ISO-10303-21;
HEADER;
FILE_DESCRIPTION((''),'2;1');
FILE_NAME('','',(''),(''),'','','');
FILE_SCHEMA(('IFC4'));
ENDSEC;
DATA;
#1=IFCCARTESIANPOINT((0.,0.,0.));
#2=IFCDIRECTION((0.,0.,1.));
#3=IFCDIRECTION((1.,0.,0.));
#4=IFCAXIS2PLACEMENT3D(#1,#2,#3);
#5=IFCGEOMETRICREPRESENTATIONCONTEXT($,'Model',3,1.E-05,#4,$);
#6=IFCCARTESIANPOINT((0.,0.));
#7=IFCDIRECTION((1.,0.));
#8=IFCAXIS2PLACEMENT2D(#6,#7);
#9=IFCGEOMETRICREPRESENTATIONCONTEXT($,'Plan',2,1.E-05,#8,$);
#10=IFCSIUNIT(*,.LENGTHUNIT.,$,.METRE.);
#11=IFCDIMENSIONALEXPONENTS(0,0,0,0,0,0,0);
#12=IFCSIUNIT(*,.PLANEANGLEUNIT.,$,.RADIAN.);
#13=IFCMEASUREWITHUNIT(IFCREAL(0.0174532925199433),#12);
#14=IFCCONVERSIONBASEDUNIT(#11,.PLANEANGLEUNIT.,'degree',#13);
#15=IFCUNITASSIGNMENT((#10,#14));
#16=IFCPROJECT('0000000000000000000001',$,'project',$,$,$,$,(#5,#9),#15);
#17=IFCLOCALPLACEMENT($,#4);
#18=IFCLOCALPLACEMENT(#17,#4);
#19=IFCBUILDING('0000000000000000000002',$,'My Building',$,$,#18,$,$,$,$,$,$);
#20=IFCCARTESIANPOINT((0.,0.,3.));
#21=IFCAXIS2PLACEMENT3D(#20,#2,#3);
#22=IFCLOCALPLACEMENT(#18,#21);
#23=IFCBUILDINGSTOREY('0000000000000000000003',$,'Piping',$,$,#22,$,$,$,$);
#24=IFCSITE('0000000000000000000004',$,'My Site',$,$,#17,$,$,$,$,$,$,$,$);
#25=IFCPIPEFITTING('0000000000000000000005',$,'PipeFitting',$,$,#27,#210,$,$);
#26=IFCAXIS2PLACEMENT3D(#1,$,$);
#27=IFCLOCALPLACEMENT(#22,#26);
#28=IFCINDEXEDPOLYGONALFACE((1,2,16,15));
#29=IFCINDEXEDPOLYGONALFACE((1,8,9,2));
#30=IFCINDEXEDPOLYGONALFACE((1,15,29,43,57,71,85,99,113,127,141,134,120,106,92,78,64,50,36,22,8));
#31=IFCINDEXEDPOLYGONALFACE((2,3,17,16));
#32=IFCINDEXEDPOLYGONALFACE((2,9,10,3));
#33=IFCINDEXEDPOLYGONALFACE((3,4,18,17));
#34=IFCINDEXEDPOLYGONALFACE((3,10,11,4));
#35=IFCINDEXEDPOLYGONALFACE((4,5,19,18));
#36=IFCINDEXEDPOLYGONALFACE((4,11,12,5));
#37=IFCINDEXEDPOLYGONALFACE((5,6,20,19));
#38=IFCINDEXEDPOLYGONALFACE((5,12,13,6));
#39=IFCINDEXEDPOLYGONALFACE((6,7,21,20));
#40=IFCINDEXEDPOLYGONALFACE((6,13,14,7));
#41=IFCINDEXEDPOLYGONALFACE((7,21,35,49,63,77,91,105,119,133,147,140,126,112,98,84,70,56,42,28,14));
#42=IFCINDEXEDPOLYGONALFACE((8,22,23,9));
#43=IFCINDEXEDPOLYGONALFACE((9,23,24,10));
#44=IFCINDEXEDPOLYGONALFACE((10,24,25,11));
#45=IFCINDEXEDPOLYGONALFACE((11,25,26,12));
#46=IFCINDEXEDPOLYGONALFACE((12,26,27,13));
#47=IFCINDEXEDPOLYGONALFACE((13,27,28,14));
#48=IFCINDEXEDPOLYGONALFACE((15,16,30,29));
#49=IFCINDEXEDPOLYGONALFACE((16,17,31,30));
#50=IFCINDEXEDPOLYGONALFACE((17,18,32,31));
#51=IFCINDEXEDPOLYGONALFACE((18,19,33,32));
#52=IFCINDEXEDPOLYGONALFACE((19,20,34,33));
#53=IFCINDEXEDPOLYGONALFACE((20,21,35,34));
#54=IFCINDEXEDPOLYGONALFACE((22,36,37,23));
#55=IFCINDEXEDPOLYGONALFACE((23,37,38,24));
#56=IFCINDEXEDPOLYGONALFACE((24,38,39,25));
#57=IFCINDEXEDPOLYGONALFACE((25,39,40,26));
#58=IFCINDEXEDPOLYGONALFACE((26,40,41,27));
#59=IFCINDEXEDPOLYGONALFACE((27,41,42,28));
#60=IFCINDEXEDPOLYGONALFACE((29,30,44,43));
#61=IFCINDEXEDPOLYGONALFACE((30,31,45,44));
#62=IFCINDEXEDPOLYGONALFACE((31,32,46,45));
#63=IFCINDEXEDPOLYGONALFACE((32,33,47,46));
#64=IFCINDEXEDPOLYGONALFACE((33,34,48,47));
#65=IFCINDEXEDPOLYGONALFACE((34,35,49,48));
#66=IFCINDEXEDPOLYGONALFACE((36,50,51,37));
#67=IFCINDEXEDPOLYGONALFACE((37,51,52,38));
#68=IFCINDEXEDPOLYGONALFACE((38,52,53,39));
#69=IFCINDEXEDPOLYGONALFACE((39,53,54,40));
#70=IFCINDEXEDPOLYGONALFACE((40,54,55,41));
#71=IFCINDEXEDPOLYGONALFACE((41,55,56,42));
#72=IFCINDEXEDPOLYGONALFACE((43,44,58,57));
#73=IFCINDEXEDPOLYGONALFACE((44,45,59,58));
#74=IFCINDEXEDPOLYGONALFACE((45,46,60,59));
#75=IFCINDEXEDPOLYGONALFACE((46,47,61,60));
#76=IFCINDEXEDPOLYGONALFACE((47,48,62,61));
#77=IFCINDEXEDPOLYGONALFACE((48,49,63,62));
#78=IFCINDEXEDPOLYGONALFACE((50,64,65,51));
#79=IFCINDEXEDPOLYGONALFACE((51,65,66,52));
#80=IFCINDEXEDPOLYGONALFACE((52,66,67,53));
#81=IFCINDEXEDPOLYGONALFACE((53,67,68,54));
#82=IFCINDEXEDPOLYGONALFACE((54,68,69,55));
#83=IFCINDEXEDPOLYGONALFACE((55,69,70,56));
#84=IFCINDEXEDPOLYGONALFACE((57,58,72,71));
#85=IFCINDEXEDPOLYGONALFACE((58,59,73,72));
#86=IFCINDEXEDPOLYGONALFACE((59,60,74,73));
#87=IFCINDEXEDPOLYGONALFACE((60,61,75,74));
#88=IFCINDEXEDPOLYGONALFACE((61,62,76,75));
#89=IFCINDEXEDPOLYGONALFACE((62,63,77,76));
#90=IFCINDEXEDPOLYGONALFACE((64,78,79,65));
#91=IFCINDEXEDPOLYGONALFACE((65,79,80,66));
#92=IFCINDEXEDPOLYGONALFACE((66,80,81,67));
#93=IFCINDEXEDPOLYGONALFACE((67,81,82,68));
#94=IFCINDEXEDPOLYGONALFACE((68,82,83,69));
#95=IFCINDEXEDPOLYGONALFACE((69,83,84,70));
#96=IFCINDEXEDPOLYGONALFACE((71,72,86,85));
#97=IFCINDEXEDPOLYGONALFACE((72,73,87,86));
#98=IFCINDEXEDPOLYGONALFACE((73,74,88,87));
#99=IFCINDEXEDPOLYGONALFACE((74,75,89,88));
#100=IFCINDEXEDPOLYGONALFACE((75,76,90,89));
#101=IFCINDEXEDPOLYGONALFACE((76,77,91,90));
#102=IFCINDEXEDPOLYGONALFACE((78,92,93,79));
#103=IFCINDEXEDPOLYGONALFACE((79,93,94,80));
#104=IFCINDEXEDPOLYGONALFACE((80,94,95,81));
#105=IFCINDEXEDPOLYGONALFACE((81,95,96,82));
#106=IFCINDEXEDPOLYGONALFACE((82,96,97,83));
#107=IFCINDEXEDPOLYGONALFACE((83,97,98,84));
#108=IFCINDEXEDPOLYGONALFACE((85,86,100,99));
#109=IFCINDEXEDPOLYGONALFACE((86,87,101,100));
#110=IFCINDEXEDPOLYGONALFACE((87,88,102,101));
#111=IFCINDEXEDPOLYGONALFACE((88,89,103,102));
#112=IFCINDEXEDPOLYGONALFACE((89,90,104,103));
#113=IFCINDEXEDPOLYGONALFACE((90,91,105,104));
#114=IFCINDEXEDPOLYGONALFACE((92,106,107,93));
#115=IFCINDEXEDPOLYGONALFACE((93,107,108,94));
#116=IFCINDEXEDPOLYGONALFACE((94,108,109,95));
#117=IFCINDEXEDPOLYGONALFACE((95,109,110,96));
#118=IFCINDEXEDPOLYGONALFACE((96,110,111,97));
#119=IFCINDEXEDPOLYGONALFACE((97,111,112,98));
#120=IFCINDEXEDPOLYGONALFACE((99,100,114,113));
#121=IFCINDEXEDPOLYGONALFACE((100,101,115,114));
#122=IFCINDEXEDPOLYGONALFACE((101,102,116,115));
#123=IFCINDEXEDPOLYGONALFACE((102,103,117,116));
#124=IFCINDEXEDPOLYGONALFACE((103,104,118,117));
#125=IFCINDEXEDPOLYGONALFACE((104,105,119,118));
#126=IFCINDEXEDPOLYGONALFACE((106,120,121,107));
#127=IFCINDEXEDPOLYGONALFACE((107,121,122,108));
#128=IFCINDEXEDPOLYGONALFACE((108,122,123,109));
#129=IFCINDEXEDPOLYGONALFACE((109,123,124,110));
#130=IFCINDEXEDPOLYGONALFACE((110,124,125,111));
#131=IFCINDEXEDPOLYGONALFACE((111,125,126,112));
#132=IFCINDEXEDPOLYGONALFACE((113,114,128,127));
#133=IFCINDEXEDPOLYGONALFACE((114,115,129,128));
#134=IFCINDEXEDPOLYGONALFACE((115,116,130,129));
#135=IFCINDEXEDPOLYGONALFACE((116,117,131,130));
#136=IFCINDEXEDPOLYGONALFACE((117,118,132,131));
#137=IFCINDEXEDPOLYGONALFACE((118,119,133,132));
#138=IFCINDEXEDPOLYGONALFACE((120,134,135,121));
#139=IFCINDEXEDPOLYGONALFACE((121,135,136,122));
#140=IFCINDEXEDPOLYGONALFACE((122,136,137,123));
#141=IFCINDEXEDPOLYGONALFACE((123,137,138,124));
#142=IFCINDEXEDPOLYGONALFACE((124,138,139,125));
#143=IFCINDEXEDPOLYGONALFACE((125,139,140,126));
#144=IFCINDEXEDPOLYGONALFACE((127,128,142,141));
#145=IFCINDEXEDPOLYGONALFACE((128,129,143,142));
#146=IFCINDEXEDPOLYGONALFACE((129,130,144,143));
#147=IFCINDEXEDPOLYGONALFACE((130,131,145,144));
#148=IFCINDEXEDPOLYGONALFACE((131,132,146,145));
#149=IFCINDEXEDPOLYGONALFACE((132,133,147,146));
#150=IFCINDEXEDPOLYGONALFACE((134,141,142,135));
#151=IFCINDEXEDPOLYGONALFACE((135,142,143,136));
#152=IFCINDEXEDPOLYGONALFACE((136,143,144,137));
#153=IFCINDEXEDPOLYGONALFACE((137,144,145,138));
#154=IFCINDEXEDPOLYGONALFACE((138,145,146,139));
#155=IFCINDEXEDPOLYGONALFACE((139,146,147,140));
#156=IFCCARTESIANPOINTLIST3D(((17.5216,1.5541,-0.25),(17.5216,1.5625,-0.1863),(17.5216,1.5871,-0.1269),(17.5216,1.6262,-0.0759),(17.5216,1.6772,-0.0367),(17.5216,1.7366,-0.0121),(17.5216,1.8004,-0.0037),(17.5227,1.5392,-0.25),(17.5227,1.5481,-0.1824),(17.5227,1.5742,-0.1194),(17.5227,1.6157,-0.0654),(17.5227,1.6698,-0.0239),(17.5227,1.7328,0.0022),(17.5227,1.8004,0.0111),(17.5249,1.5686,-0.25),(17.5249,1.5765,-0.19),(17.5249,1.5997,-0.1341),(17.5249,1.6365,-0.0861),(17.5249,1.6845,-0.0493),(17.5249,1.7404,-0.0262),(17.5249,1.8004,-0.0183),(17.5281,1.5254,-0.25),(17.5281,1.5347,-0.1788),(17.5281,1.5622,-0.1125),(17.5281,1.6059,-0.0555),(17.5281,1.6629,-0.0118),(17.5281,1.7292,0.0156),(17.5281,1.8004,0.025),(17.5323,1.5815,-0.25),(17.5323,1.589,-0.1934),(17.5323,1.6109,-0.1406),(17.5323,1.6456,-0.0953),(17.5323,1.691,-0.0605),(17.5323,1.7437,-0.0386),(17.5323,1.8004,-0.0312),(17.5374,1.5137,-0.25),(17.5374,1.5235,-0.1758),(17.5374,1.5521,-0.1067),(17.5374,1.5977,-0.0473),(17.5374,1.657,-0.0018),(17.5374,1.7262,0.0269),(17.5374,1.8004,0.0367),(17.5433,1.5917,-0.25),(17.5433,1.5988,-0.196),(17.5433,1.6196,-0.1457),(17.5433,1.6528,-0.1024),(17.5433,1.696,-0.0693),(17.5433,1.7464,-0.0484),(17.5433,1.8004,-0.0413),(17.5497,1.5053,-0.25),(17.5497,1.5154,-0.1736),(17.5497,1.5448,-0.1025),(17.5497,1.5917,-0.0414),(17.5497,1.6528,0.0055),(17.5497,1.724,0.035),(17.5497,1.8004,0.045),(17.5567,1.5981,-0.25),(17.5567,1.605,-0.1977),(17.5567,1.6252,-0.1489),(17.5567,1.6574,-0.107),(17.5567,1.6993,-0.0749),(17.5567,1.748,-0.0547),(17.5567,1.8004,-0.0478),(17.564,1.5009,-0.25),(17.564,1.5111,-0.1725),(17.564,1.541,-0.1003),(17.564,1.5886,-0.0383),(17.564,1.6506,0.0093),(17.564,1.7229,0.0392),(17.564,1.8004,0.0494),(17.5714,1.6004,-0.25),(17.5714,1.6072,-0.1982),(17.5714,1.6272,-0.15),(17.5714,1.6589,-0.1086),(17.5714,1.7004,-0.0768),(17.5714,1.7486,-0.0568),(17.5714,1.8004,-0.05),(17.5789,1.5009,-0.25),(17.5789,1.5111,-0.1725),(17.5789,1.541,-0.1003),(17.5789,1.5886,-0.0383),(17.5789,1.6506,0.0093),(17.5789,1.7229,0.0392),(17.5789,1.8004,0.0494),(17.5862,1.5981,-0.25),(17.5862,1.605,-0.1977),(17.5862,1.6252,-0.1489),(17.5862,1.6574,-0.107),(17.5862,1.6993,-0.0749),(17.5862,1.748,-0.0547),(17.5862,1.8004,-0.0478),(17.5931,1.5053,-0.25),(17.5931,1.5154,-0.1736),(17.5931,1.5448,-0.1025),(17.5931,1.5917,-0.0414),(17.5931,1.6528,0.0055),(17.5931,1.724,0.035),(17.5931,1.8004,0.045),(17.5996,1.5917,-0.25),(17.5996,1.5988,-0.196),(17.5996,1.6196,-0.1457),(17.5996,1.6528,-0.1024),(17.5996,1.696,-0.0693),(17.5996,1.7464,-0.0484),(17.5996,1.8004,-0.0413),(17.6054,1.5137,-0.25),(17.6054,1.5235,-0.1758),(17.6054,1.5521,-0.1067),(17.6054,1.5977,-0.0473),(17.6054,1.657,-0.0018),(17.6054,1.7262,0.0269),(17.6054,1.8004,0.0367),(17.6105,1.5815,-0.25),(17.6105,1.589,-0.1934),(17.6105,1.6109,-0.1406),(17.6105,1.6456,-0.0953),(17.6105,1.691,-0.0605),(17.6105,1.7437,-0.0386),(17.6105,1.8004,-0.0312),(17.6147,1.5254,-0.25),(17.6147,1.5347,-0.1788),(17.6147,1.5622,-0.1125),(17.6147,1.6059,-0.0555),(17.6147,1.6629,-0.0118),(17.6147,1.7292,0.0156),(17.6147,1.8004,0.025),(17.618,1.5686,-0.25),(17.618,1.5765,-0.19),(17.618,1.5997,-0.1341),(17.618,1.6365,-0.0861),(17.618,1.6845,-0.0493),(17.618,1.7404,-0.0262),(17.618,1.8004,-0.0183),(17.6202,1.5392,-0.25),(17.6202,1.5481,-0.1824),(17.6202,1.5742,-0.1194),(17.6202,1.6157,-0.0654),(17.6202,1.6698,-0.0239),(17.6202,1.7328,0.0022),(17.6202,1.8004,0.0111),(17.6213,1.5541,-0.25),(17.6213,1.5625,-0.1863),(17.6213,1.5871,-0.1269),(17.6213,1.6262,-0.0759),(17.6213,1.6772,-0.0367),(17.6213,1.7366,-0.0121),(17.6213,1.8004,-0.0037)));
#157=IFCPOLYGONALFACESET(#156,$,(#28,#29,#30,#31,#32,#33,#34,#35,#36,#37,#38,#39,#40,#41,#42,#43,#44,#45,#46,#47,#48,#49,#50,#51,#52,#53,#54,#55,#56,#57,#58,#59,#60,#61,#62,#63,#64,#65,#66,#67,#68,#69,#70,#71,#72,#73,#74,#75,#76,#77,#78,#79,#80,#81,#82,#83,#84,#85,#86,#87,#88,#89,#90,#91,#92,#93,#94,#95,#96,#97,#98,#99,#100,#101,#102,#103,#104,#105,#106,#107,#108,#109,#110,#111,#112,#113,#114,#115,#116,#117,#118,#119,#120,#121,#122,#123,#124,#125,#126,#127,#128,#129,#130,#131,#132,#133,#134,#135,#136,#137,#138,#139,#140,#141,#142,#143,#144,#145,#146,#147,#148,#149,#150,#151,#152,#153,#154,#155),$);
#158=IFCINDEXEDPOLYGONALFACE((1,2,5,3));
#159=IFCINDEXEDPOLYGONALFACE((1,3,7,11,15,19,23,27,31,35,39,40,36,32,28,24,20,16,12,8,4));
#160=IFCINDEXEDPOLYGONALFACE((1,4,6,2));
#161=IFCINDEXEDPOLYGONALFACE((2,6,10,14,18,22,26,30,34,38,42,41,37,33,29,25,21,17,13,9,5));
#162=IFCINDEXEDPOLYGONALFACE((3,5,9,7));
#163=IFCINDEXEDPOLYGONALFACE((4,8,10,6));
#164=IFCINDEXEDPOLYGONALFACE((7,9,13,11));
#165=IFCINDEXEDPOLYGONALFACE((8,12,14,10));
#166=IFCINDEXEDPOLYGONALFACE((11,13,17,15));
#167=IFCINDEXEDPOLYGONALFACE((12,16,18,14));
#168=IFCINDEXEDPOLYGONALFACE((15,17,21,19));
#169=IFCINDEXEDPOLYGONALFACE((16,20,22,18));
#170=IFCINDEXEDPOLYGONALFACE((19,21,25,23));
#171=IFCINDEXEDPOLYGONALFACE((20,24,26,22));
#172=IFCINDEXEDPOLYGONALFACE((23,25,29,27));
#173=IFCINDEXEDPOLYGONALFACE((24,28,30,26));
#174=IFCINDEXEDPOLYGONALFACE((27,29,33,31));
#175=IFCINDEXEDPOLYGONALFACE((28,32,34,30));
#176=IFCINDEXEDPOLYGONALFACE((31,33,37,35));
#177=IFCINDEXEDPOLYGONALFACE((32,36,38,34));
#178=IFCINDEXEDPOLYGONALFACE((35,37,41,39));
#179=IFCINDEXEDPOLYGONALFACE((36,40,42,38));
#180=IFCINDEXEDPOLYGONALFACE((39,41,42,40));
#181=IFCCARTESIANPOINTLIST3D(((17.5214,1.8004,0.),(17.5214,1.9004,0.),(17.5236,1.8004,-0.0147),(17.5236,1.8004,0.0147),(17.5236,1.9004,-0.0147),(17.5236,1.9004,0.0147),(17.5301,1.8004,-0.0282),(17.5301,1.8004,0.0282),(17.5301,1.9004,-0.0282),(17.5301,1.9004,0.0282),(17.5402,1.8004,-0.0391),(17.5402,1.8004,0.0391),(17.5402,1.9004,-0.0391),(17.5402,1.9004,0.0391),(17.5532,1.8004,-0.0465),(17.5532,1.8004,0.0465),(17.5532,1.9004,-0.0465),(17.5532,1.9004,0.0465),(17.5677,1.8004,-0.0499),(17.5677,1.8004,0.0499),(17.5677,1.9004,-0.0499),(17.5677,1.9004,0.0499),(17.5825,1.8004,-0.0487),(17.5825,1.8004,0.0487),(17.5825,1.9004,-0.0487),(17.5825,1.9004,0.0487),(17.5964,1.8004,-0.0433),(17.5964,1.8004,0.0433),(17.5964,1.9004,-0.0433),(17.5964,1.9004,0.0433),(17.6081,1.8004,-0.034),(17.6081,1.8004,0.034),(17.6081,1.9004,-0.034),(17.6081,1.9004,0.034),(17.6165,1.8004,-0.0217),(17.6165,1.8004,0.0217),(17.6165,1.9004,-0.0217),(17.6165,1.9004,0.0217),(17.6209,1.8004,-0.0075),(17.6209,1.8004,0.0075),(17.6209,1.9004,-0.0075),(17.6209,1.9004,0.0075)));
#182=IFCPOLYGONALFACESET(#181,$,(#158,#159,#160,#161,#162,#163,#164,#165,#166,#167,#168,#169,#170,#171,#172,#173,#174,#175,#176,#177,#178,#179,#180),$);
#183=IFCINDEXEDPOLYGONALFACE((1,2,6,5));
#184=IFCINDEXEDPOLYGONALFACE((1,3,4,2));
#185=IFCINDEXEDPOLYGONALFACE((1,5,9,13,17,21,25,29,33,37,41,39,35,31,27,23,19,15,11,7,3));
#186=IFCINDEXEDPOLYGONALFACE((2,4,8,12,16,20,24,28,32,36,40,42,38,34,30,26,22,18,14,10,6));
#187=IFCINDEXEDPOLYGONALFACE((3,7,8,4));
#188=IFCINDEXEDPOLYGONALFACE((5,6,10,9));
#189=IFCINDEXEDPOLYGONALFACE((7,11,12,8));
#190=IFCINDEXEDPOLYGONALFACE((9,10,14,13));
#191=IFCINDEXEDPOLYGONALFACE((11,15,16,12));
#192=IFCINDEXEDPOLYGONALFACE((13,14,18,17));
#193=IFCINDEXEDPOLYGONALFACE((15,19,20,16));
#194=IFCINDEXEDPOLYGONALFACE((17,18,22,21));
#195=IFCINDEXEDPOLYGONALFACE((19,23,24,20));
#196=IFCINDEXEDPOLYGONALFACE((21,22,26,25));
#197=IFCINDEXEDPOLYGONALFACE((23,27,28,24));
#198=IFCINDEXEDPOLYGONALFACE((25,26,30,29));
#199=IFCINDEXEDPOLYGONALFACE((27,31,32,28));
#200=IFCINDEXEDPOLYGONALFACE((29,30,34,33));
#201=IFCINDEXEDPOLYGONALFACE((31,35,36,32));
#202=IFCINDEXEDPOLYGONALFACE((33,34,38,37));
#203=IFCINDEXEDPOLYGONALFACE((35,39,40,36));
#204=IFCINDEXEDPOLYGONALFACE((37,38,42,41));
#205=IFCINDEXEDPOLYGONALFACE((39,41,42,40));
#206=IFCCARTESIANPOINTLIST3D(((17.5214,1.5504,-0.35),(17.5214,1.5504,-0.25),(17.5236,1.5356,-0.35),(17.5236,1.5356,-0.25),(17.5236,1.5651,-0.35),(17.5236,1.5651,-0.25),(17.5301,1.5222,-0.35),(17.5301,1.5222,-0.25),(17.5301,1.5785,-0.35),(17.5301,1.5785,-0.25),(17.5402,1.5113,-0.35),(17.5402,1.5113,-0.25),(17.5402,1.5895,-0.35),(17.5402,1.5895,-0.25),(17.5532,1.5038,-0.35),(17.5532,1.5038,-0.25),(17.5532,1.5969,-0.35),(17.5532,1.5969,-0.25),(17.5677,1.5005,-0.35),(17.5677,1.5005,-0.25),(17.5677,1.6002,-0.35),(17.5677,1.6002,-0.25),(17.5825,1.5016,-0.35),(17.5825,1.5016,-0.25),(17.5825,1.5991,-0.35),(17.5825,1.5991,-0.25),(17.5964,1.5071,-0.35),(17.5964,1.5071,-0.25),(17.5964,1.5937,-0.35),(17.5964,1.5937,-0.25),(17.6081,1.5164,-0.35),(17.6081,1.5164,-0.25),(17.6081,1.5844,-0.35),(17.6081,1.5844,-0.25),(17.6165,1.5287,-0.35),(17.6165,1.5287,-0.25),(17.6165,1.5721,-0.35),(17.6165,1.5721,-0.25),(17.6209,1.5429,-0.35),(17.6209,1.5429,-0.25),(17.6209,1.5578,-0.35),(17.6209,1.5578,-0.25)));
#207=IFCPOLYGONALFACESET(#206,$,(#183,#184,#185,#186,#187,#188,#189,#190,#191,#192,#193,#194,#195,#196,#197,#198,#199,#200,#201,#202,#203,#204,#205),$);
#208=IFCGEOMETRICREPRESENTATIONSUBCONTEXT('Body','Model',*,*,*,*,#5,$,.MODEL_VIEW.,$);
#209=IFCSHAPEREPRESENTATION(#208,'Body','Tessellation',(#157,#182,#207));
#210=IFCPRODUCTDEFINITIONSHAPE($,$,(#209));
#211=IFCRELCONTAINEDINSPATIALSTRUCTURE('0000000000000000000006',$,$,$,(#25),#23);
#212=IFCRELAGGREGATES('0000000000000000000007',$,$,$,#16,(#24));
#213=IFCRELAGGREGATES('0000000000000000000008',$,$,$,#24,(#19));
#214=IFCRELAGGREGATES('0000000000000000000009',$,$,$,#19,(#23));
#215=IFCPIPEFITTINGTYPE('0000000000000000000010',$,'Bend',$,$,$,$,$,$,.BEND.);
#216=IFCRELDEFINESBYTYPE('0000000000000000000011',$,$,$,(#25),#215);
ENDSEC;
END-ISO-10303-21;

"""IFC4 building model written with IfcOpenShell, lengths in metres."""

from ifc_helpers import new_model, entity, si_unit, converted_unit, frame, origin_with_axes, origin_2d_with_axis, place, context, subcontext, project, spatial, circle, extrude, source, transform, mapped, type_object, type_shapes, element, save


model = new_model("IFC4")

# Units and contexts
model_context = context("Model", 3, precision=1e-05, world=origin_with_axes())
plan_context = context("Plan", 2, precision=1e-05, world=origin_2d_with_axis())
body_context = subcontext(model_context, "Body", "Model", "MODEL_VIEW")
ifc_project = project(units=[si_unit("LENGTHUNIT", "METRE"), converted_unit("PLANEANGLEUNIT", "degree", entity("IfcReal", 0.0174532925199433), si_unit("PLANEANGLEUNIT", "RADIAN"), dimensions=[0, 0, 0, 0, 0, 0, 0])], contexts=[model_context, plan_context])

# Site, building, storey
site_placement = place(None, origin_with_axes())
site = spatial("IfcSite", under=ifc_project, at=site_placement, Name="My Site")
building_placement = place(site_placement, origin_with_axes())
building = spatial("IfcBuilding", under=site, at=building_placement, Name="My Building")
storey_placement = place(building_placement, frame((0.0, 0.0, 3.0), z_axis=(0.0, 0.0, 1.0), x_axis=(1.0, 0.0, 0.0)))
storey = spatial("IfcBuildingStorey", under=building, at=storey_placement, Name="Piping")

# Pipe fitting
pipe_fitting_type = type_object("IfcPipeFittingType", Name="Bend", PredefinedType="BEND")
shared_shape = source(origin_with_axes(), body_context, "Body", "SolidModel", [
    entity("IfcSweptDiskSolid", entity("IfcIndexedPolyCurve", entity("IfcCartesianPointList3D", [[0.0, 0.0, -0.1], [0.0, -0.0732, -0.2768], [0.0, -0.25, -0.35]]), [entity("IfcArcIndex", [1, 2, 3])]), 0.05),
    extrude(circle(Radius=0.05), origin_with_axes(), (0.0, 0.0, -1.0), 0.1),
    extrude(circle(Radius=0.05), frame((0.0, -0.25, -0.35), z_axis=(0.0, -1.0, 0.0), x_axis=(1.0, 0.0, 0.0)), (0.0, 0.0, 1.0), 0.1),
])
type_shapes(pipe_fitting_type, [shared_shape])
for number, where, z_axis, x_axis, name in (
    (1, (17.5714, 1.9004, 0.0), (0.0, 1.0, 0.0), (-1.0, 0.0, 0.0), "PipeFitting"),
):
    element("IfcPipeFitting", number, at=place(storey_placement, frame(where, z_axis=z_axis, x_axis=x_axis)), inside=storey, type_object=pipe_fitting_type, Name=name, context=body_context, shape_type="MappedRepresentation", body=[
        mapped(shared_shape, transform((0.0, 0.0, 0.0), x_axis=(1.0, 0.0, 0.0), y_axis=(0.0, 1.0, 0.0), z_axis=(0.0, 0.0, 1.0), scale=1.0)),
    ])

save(model, "model.ifc")
